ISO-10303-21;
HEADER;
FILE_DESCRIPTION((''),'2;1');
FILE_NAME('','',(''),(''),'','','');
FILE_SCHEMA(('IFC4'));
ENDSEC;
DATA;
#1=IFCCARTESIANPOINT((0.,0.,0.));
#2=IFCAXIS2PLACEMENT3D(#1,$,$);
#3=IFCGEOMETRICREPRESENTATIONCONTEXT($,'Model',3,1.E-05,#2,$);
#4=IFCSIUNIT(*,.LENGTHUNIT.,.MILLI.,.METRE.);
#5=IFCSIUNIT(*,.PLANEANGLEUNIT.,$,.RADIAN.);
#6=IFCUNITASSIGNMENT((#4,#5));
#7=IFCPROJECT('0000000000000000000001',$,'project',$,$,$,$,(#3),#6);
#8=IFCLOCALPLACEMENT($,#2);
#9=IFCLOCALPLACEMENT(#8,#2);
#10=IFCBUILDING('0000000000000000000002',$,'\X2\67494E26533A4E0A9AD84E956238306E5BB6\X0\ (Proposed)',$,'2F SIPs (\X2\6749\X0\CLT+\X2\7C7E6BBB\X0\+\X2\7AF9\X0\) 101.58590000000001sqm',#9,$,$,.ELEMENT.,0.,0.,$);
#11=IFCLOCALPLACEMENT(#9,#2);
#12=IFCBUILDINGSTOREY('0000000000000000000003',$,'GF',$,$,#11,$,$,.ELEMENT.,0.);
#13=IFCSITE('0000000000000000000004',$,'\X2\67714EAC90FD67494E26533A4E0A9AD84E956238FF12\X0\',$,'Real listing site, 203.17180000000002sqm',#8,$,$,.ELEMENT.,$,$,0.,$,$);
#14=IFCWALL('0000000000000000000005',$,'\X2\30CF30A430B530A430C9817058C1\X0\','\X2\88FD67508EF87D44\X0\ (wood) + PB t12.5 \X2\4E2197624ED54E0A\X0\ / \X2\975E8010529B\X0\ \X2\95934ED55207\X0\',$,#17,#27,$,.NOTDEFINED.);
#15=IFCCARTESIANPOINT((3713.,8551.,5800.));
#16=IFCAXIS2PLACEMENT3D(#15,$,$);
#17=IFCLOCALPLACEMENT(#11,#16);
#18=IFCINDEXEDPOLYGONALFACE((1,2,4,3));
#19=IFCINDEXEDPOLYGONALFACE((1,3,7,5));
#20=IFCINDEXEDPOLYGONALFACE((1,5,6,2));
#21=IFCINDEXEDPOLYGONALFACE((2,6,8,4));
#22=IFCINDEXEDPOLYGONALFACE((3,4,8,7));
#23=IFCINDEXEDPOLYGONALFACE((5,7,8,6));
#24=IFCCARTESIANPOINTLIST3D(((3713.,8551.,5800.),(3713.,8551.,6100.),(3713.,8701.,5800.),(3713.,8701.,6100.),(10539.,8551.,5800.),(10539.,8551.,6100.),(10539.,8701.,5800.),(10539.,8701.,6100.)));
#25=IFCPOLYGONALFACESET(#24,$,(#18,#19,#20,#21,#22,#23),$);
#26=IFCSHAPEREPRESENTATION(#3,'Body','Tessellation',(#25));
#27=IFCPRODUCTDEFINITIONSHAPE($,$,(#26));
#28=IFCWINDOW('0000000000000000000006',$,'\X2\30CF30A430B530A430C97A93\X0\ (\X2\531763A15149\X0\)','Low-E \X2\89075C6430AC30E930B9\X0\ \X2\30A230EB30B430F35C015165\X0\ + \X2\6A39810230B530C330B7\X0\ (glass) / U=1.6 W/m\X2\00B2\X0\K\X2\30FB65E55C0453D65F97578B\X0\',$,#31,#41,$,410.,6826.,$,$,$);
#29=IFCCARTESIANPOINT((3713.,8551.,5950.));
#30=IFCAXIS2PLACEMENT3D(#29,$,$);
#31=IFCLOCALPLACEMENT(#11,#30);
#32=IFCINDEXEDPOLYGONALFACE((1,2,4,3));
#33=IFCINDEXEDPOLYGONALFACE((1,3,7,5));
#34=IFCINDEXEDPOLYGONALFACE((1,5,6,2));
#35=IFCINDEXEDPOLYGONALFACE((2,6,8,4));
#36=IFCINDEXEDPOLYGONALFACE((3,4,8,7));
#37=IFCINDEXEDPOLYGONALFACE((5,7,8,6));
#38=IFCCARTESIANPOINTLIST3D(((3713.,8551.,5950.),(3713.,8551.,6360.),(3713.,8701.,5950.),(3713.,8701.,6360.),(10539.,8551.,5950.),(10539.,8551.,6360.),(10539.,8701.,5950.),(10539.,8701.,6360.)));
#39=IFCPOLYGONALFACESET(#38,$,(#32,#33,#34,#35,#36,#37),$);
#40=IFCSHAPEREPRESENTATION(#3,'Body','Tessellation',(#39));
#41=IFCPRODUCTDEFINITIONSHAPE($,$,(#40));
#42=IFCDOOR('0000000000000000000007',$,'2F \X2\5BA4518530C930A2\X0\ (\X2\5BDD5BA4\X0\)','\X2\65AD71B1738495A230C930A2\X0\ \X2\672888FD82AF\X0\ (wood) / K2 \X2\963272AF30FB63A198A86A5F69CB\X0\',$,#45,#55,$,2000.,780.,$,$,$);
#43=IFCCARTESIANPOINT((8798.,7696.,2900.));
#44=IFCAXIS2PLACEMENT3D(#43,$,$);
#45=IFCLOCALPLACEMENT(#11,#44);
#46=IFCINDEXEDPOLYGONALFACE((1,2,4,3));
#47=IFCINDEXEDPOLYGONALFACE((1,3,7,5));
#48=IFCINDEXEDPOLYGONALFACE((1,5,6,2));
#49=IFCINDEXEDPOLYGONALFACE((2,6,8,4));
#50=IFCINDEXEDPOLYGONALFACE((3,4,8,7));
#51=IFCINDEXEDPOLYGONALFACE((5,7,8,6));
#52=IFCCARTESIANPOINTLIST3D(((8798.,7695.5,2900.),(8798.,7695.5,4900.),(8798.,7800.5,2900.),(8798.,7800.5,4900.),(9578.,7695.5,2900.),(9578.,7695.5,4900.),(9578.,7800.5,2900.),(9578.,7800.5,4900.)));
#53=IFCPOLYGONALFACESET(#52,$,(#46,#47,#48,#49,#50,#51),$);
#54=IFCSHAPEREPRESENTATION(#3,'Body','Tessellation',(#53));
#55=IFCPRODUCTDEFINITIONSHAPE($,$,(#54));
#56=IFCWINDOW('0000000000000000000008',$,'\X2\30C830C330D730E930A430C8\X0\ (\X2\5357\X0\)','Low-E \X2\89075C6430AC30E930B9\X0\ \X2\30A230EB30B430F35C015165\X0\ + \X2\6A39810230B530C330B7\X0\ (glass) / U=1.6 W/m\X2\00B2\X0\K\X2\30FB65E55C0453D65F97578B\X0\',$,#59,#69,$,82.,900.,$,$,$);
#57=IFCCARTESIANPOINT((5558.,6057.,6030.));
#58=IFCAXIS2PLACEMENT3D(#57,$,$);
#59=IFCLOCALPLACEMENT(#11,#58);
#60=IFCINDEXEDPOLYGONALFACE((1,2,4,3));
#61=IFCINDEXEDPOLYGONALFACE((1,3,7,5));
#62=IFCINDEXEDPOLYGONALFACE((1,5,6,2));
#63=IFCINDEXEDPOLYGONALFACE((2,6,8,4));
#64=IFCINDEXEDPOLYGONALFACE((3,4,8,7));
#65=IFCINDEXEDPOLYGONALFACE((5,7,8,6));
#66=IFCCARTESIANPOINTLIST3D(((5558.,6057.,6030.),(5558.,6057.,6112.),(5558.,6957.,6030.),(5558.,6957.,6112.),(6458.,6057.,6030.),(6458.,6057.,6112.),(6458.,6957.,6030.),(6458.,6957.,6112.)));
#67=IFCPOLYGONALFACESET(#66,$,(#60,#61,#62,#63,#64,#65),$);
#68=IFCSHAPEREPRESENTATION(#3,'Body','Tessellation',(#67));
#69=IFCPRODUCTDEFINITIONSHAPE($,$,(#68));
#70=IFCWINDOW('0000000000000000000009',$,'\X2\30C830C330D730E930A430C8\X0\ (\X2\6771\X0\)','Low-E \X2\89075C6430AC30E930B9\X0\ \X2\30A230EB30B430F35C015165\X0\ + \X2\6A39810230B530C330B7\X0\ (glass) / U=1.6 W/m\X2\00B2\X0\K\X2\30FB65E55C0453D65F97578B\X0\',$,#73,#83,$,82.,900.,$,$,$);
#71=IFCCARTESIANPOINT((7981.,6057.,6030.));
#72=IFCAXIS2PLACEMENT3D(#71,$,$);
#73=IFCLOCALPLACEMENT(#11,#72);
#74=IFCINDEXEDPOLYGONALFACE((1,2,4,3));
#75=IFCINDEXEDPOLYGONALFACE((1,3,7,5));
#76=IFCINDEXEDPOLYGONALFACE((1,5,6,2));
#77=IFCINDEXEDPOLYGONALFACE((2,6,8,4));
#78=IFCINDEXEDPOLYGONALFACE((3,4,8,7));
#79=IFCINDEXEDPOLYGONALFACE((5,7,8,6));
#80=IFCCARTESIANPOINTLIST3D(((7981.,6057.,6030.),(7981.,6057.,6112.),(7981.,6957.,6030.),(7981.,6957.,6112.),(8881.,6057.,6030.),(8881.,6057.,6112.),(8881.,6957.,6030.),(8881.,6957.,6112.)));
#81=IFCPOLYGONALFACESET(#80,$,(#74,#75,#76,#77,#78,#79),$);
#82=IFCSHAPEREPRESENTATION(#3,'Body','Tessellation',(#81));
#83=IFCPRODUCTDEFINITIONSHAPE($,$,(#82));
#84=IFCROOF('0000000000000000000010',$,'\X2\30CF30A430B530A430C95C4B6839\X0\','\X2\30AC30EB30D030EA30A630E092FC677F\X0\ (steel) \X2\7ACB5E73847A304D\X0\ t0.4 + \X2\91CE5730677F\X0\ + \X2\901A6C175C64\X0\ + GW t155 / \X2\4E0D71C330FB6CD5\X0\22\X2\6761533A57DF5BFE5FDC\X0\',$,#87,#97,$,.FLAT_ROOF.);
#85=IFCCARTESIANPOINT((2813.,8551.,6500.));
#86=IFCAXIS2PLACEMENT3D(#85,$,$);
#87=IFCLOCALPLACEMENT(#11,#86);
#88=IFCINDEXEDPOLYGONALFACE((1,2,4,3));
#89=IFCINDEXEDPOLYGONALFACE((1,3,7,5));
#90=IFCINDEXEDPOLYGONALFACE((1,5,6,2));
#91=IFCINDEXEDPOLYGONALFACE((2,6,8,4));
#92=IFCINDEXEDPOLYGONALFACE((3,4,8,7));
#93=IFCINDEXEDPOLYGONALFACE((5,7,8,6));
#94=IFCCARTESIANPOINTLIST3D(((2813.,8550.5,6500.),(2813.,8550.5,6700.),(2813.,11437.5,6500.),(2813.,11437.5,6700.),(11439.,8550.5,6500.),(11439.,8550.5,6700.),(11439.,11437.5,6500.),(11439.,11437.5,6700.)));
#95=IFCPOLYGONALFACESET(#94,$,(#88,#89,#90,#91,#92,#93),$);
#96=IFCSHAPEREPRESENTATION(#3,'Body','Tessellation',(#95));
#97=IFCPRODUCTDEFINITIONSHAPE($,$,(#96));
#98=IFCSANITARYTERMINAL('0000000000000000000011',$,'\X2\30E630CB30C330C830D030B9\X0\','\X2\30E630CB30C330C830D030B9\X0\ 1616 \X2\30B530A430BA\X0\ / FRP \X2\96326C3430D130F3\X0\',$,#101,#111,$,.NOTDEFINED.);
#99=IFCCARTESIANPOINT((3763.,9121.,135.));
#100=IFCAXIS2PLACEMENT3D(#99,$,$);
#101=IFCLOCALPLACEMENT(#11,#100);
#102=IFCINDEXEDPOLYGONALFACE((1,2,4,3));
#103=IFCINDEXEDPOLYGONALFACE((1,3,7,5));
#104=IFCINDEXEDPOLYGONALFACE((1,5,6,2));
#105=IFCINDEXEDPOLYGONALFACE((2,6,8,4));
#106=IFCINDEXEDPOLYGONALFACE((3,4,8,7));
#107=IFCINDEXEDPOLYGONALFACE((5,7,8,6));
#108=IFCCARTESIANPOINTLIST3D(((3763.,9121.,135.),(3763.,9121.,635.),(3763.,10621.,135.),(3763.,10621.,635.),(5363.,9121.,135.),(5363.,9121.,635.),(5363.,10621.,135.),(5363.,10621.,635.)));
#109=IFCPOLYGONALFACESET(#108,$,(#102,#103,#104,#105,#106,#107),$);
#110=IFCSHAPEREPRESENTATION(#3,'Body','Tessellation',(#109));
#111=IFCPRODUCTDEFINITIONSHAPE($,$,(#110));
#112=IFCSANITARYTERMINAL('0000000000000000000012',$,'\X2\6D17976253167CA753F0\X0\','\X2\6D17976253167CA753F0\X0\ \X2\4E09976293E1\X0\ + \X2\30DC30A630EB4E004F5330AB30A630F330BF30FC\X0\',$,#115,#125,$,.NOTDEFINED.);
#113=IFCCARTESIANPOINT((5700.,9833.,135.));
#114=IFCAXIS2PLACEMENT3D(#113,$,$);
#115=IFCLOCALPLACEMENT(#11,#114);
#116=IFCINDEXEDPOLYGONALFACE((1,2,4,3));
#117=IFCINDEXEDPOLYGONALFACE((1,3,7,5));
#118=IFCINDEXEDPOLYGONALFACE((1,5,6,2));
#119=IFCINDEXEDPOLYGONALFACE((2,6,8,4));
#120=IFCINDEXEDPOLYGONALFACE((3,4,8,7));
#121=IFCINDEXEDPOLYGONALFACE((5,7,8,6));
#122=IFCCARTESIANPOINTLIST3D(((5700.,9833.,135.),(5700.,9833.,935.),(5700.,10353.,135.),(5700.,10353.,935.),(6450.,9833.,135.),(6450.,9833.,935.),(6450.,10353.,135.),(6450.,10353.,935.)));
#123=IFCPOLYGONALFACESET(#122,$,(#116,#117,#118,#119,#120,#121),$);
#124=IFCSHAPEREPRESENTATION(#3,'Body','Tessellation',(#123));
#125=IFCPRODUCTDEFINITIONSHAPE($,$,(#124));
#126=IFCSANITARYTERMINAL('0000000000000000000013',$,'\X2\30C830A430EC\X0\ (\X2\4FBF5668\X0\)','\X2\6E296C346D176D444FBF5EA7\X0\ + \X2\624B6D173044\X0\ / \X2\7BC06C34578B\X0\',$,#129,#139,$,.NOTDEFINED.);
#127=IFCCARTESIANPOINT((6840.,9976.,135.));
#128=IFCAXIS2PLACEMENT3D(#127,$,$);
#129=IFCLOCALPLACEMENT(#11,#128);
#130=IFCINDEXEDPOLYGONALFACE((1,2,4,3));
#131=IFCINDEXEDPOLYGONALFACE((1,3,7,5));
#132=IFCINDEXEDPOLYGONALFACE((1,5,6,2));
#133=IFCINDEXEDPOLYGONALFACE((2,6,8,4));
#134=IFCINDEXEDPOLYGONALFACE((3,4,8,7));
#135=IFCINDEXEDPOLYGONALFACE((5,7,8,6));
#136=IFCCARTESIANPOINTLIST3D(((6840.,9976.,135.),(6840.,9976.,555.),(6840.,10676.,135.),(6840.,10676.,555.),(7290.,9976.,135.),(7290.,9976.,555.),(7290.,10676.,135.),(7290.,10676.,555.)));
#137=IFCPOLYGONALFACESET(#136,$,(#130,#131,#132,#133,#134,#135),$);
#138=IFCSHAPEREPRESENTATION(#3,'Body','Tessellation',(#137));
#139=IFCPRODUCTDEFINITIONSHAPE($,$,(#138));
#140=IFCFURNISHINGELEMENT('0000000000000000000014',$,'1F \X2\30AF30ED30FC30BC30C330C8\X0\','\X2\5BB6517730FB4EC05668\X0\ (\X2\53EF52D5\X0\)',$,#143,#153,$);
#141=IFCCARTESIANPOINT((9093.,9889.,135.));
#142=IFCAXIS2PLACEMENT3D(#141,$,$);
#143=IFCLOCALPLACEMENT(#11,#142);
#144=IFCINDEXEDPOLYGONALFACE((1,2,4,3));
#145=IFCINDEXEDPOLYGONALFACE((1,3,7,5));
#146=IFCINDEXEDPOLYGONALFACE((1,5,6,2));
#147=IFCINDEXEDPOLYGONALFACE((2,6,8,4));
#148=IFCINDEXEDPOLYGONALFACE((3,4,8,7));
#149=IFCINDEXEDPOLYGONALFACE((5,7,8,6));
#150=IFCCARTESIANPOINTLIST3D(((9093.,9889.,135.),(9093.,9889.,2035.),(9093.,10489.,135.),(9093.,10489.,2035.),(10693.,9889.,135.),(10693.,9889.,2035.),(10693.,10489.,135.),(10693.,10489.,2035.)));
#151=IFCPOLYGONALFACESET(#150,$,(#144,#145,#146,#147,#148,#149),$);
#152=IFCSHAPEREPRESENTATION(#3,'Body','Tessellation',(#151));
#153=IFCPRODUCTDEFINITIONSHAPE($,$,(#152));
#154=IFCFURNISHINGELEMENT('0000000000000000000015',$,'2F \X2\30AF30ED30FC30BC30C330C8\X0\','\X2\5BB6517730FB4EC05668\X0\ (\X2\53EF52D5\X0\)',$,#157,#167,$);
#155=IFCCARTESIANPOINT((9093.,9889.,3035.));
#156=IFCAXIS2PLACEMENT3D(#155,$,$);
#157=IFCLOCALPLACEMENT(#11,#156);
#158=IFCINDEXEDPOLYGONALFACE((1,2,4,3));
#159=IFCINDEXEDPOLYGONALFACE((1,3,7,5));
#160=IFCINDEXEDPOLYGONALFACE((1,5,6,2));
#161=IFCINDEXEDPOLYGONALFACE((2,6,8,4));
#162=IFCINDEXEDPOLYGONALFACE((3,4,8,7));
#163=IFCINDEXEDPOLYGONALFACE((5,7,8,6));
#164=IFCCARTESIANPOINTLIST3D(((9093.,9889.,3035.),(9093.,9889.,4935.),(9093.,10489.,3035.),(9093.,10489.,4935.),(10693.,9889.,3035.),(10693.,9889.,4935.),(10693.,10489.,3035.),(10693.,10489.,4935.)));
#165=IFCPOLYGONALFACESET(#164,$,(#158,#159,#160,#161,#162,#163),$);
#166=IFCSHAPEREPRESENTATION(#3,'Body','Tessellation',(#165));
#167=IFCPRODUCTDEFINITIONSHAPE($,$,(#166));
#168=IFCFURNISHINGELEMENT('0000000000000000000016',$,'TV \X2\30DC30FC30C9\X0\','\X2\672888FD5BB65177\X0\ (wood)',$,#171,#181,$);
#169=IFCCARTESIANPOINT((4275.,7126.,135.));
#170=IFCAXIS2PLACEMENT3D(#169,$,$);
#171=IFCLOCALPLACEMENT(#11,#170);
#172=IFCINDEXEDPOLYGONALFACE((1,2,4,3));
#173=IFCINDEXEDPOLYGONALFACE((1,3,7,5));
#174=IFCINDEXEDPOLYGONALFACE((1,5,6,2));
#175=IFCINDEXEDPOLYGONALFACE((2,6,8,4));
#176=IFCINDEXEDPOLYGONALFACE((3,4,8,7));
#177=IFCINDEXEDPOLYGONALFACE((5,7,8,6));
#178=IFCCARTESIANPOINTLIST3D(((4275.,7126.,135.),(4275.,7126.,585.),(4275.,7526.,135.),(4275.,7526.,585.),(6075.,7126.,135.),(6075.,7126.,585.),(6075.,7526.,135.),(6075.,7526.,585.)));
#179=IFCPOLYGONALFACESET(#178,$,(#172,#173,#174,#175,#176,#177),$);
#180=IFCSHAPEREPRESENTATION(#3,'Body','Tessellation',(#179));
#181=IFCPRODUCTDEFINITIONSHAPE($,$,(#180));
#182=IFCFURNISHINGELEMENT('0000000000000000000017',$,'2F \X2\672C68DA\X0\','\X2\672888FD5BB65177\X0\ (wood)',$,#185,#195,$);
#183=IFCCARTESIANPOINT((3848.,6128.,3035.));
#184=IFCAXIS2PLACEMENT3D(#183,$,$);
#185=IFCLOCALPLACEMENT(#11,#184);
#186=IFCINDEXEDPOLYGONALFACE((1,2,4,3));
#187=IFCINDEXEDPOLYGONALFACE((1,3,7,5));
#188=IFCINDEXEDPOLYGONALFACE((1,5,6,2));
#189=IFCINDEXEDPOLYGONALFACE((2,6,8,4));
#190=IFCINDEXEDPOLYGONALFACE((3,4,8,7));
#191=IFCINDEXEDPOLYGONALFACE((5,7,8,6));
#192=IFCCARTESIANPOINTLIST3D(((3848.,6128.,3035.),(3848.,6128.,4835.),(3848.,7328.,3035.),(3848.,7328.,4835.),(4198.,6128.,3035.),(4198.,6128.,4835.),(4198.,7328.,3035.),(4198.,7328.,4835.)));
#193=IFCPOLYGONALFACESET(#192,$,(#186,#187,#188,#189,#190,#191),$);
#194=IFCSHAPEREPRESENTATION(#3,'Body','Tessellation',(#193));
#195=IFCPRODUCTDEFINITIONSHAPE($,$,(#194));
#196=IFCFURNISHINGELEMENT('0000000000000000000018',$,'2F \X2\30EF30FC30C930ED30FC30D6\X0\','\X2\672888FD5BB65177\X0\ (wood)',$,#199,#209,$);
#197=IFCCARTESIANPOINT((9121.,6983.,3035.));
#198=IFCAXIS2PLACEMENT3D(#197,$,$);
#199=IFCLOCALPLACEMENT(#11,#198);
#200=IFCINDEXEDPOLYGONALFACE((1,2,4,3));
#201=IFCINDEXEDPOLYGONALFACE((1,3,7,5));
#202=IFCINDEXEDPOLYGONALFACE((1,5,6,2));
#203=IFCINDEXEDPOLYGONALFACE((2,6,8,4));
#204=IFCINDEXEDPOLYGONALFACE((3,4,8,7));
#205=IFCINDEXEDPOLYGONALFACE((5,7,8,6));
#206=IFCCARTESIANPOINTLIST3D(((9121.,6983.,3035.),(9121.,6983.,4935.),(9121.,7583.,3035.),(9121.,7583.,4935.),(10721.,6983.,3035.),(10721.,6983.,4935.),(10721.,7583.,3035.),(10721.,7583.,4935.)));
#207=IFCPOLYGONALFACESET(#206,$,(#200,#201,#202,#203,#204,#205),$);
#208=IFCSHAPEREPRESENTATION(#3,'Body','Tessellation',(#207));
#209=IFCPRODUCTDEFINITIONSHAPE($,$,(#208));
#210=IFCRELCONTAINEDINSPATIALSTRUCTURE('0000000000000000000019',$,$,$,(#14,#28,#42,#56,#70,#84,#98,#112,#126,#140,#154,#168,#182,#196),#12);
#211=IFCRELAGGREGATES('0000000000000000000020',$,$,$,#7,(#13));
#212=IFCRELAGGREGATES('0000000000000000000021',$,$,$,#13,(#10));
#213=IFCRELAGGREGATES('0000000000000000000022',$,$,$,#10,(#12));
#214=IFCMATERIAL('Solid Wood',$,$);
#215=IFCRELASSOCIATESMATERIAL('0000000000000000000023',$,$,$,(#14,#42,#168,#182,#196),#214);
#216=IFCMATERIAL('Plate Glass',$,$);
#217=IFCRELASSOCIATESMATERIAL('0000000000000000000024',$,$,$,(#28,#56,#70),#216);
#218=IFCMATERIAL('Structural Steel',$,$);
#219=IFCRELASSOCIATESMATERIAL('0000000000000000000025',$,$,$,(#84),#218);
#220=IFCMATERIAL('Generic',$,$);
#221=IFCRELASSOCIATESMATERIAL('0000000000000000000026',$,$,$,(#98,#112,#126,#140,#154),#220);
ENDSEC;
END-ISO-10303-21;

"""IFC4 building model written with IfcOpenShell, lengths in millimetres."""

from ifc_helpers import new_model, si_unit, frame, frame_2d, origin, place, context, project, spatial, rectangle, extrude, material, element, fill, save


model = new_model("IFC4")

# Units and contexts
model_context = context("Model", 3, precision=1e-05, world=origin())
ifc_project = project(units=[si_unit("LENGTHUNIT", "METRE", prefix="MILLI"), si_unit("PLANEANGLEUNIT", "RADIAN")], contexts=[model_context])

# Site, building, storey
site_placement = place(None, origin())
site = spatial("IfcSite", under=ifc_project, at=site_placement, Name="東京都杉並区上高井戸２", ObjectType="Real listing site, 203.17180000000002sqm", CompositionType="ELEMENT", RefElevation=0.0)
building_placement = place(site_placement, origin())
building = spatial("IfcBuilding", under=site, at=building_placement, Name="杉並区上高井戸の家 (Proposed)", ObjectType="2F SIPs (杉CLT+籾殻+竹) 101.58590000000001sqm", CompositionType="ELEMENT", ElevationOfRefHeight=0.0, ElevationOfTerrain=0.0)
storey_placement = place(building_placement, origin())
storey = spatial("IfcBuildingStorey", under=building, at=storey_placement, Name="GF", CompositionType="ELEMENT", Elevation=0.0)

# Shared definitions
ifc_material_1 = material(Name="Solid Wood")
ifc_material_2 = material(Name="Plate Glass")

# Wall, opening, window
wall_1_placement = place(storey_placement, frame((3713.0, 8551.0, 5800.0)))
wall_1 = element("IfcWall", 1, at=wall_1_placement, inside=storey, material=ifc_material_1, Name="ハイサイド腰壁", Description="製材軸組 (wood) + PB t12.5 両面仕上 / 非耐力 間仕切", PredefinedType="NOTDEFINED", context=model_context, shape_type="SweptSolid", body=[
    extrude(rectangle(XDim=6826.0, YDim=150.0, at=frame_2d((3413.0, 75.0))), frame((3713.0, 8551.0, 5800.0)), (0.0, 0.0, 1.0), 700.0),
])
opening_1_placement = place(storey_placement, frame((3713.0, 8551.0, 5950.0)))
opening_1 = element("IfcOpeningElement", 2, at=opening_1_placement, cuts=wall_1, PredefinedType="NOTDEFINED", context=model_context, shape_type="SweptSolid", body=[
    extrude(rectangle(XDim=6826.0, YDim=150.0, at=frame_2d((3413.0, 75.0))), frame((3713.0, 8551.0, 5950.0)), (0.0, 0.0, 1.0), 410.0),
])
window_1_placement = place(storey_placement, frame((3713.0, 8551.0, 5950.0)))
window_1 = element("IfcWindow", 3, at=window_1_placement, inside=storey, material=ifc_material_2, Name="ハイサイド窓 (北採光)", Description="Low-E 複層ガラス アルゴン封入 + 樹脂サッシ (glass) / U=1.6 W/m²K・日射取得型", OverallHeight=410.0, OverallWidth=6826.0, context=model_context, shape_type="SweptSolid", body=[
    extrude(rectangle(XDim=6826.0, YDim=150.0, at=frame_2d((3413.0, 75.0))), frame((3713.0, 8551.0, 5950.0)), (0.0, 0.0, 1.0), 410.0),
])
fill(opening_1, window_1)

# Door
door_1_placement = place(storey_placement, frame((8798.0, 7696.0, 2900.0)))
element("IfcDoor", 4, at=door_1_placement, inside=storey, material=ifc_material_1, Name="2F 室内ドア (寝室)", Description="断熱玄関ドア 木製芯 (wood) / K2 防犯・採風機構", OverallHeight=2000.0, OverallWidth=780.0, context=model_context, shape_type="SweptSolid", body=[
    extrude(rectangle(XDim=780.0, YDim=105.0, at=frame_2d((390.0, 52.0))), frame((8798.0, 7696.0, 2900.0)), (0.0, 0.0, 1.0), 2000.0),
])

# Windows
window_2_placement = place(storey_placement, frame((5558.0, 6057.0, 6030.0)))
element("IfcWindow", 5, at=window_2_placement, inside=storey, material=ifc_material_2, Name="トップライト (南)", Description="Low-E 複層ガラス アルゴン封入 + 樹脂サッシ (glass) / U=1.6 W/m²K・日射取得型", OverallHeight=82.0, OverallWidth=900.0, context=model_context, shape_type="SweptSolid", body=[
    extrude(rectangle(XDim=900.0, YDim=900.0, at=frame_2d((450.0, 450.0))), frame((5558.0, 6057.0, 6030.0)), (0.0, 0.0, 1.0), 82.0),
])
window_3_placement = place(storey_placement, frame((7981.0, 6057.0, 6030.0)))
element("IfcWindow", 6, at=window_3_placement, inside=storey, material=ifc_material_2, Name="トップライト (東)", Description="Low-E 複層ガラス アルゴン封入 + 樹脂サッシ (glass) / U=1.6 W/m²K・日射取得型", OverallHeight=82.0, OverallWidth=900.0, context=model_context, shape_type="SweptSolid", body=[
    extrude(rectangle(XDim=900.0, YDim=900.0, at=frame_2d((450.0, 450.0))), frame((7981.0, 6057.0, 6030.0)), (0.0, 0.0, 1.0), 82.0),
])

# Roof
ifc_material_3 = material(Name="Structural Steel")
roof_placement = place(storey_placement, frame((2813.0, 8551.0, 6500.0)))
element("IfcRoof", 7, at=roof_placement, inside=storey, material=ifc_material_3, Name="ハイサイド屋根", Description="ガルバリウム鋼板 (steel) 立平葺き t0.4 + 野地板 + 通気層 + GW t155 / 不燃・法22条区域対応", PredefinedType="FLAT_ROOF", context=model_context, shape_type="SweptSolid", body=[
    extrude(rectangle(XDim=8626.0, YDim=2887.0, at=frame_2d((4313.0, 1443.0))), frame((2813.0, 8551.0, 6500.0)), (0.0, 0.0, 1.0), 200.0),
])

# Sanitary terminals
ifc_material_4 = material(Name="Generic")
sanitary_terminal_1_placement = place(storey_placement, frame((3763.0, 9121.0, 135.0)))
element("IfcSanitaryTerminal", 8, at=sanitary_terminal_1_placement, inside=storey, material=ifc_material_4, Name="ユニットバス", Description="ユニットバス 1616 サイズ / FRP 防水パン", PredefinedType="NOTDEFINED", context=model_context, shape_type="SweptSolid", body=[
    extrude(rectangle(XDim=1600.0, YDim=1500.0, at=frame_2d((800.0, 750.0))), frame((3763.0, 9121.0, 135.0)), (0.0, 0.0, 1.0), 500.0),
])
sanitary_terminal_2_placement = place(storey_placement, frame((5700.0, 9833.0, 135.0)))
element("IfcSanitaryTerminal", 9, at=sanitary_terminal_2_placement, inside=storey, material=ifc_material_4, Name="洗面化粧台", Description="洗面化粧台 三面鏡 + ボウル一体カウンター", PredefinedType="NOTDEFINED", context=model_context, shape_type="SweptSolid", body=[
    extrude(rectangle(XDim=750.0, YDim=520.0, at=frame_2d((375.0, 260.0))), frame((5700.0, 9833.0, 135.0)), (0.0, 0.0, 1.0), 800.0),
])
sanitary_terminal_3_placement = place(storey_placement, frame((6840.0, 9976.0, 135.0)))
element("IfcSanitaryTerminal", 10, at=sanitary_terminal_3_placement, inside=storey, material=ifc_material_4, Name="トイレ (便器)", Description="温水洗浄便座 + 手洗い / 節水型", PredefinedType="NOTDEFINED", context=model_context, shape_type="SweptSolid", body=[
    extrude(rectangle(XDim=450.0, YDim=700.0, at=frame_2d((225.0, 350.0))), frame((6840.0, 9976.0, 135.0)), (0.0, 0.0, 1.0), 420.0),
])

# Furnishing elements
furnishing_1_placement = place(storey_placement, frame((9093.0, 9889.0, 135.0)))
element("IfcFurnishingElement", 11, at=furnishing_1_placement, inside=storey, material=ifc_material_4, Name="1F クローゼット", Description="家具・什器 (可動)", context=model_context, shape_type="SweptSolid", body=[
    extrude(rectangle(XDim=1600.0, YDim=600.0, at=frame_2d((800.0, 300.0))), frame((9093.0, 9889.0, 135.0)), (0.0, 0.0, 1.0), 1900.0),
])
furnishing_2_placement = place(storey_placement, frame((9093.0, 9889.0, 3035.0)))
element("IfcFurnishingElement", 12, at=furnishing_2_placement, inside=storey, material=ifc_material_4, Name="2F クローゼット", Description="家具・什器 (可動)", context=model_context, shape_type="SweptSolid", body=[
    extrude(rectangle(XDim=1600.0, YDim=600.0, at=frame_2d((800.0, 300.0))), frame((9093.0, 9889.0, 3035.0)), (0.0, 0.0, 1.0), 1900.0),
])
furnishing_3_placement = place(storey_placement, frame((4275.0, 7126.0, 135.0)))
element("IfcFurnishingElement", 13, at=furnishing_3_placement, inside=storey, material=ifc_material_1, Name="TV ボード", Description="木製家具 (wood)", context=model_context, shape_type="SweptSolid", body=[
    extrude(rectangle(XDim=1800.0, YDim=400.0, at=frame_2d((900.0, 200.0))), frame((4275.0, 7126.0, 135.0)), (0.0, 0.0, 1.0), 450.0),
])
furnishing_4_placement = place(storey_placement, frame((3848.0, 6128.0, 3035.0)))
element("IfcFurnishingElement", 14, at=furnishing_4_placement, inside=storey, material=ifc_material_1, Name="2F 本棚", Description="木製家具 (wood)", context=model_context, shape_type="SweptSolid", body=[
    extrude(rectangle(XDim=350.0, YDim=1200.0, at=frame_2d((175.0, 600.0))), frame((3848.0, 6128.0, 3035.0)), (0.0, 0.0, 1.0), 1800.0),
])
furnishing_5_placement = place(storey_placement, frame((9121.0, 6983.0, 3035.0)))
element("IfcFurnishingElement", 15, at=furnishing_5_placement, inside=storey, material=ifc_material_1, Name="2F ワードローブ", Description="木製家具 (wood)", context=model_context, shape_type="SweptSolid", body=[
    extrude(rectangle(XDim=1600.0, YDim=600.0, at=frame_2d((800.0, 300.0))), frame((9121.0, 6983.0, 3035.0)), (0.0, 0.0, 1.0), 1900.0),
])

save(model, "model.ifc")
